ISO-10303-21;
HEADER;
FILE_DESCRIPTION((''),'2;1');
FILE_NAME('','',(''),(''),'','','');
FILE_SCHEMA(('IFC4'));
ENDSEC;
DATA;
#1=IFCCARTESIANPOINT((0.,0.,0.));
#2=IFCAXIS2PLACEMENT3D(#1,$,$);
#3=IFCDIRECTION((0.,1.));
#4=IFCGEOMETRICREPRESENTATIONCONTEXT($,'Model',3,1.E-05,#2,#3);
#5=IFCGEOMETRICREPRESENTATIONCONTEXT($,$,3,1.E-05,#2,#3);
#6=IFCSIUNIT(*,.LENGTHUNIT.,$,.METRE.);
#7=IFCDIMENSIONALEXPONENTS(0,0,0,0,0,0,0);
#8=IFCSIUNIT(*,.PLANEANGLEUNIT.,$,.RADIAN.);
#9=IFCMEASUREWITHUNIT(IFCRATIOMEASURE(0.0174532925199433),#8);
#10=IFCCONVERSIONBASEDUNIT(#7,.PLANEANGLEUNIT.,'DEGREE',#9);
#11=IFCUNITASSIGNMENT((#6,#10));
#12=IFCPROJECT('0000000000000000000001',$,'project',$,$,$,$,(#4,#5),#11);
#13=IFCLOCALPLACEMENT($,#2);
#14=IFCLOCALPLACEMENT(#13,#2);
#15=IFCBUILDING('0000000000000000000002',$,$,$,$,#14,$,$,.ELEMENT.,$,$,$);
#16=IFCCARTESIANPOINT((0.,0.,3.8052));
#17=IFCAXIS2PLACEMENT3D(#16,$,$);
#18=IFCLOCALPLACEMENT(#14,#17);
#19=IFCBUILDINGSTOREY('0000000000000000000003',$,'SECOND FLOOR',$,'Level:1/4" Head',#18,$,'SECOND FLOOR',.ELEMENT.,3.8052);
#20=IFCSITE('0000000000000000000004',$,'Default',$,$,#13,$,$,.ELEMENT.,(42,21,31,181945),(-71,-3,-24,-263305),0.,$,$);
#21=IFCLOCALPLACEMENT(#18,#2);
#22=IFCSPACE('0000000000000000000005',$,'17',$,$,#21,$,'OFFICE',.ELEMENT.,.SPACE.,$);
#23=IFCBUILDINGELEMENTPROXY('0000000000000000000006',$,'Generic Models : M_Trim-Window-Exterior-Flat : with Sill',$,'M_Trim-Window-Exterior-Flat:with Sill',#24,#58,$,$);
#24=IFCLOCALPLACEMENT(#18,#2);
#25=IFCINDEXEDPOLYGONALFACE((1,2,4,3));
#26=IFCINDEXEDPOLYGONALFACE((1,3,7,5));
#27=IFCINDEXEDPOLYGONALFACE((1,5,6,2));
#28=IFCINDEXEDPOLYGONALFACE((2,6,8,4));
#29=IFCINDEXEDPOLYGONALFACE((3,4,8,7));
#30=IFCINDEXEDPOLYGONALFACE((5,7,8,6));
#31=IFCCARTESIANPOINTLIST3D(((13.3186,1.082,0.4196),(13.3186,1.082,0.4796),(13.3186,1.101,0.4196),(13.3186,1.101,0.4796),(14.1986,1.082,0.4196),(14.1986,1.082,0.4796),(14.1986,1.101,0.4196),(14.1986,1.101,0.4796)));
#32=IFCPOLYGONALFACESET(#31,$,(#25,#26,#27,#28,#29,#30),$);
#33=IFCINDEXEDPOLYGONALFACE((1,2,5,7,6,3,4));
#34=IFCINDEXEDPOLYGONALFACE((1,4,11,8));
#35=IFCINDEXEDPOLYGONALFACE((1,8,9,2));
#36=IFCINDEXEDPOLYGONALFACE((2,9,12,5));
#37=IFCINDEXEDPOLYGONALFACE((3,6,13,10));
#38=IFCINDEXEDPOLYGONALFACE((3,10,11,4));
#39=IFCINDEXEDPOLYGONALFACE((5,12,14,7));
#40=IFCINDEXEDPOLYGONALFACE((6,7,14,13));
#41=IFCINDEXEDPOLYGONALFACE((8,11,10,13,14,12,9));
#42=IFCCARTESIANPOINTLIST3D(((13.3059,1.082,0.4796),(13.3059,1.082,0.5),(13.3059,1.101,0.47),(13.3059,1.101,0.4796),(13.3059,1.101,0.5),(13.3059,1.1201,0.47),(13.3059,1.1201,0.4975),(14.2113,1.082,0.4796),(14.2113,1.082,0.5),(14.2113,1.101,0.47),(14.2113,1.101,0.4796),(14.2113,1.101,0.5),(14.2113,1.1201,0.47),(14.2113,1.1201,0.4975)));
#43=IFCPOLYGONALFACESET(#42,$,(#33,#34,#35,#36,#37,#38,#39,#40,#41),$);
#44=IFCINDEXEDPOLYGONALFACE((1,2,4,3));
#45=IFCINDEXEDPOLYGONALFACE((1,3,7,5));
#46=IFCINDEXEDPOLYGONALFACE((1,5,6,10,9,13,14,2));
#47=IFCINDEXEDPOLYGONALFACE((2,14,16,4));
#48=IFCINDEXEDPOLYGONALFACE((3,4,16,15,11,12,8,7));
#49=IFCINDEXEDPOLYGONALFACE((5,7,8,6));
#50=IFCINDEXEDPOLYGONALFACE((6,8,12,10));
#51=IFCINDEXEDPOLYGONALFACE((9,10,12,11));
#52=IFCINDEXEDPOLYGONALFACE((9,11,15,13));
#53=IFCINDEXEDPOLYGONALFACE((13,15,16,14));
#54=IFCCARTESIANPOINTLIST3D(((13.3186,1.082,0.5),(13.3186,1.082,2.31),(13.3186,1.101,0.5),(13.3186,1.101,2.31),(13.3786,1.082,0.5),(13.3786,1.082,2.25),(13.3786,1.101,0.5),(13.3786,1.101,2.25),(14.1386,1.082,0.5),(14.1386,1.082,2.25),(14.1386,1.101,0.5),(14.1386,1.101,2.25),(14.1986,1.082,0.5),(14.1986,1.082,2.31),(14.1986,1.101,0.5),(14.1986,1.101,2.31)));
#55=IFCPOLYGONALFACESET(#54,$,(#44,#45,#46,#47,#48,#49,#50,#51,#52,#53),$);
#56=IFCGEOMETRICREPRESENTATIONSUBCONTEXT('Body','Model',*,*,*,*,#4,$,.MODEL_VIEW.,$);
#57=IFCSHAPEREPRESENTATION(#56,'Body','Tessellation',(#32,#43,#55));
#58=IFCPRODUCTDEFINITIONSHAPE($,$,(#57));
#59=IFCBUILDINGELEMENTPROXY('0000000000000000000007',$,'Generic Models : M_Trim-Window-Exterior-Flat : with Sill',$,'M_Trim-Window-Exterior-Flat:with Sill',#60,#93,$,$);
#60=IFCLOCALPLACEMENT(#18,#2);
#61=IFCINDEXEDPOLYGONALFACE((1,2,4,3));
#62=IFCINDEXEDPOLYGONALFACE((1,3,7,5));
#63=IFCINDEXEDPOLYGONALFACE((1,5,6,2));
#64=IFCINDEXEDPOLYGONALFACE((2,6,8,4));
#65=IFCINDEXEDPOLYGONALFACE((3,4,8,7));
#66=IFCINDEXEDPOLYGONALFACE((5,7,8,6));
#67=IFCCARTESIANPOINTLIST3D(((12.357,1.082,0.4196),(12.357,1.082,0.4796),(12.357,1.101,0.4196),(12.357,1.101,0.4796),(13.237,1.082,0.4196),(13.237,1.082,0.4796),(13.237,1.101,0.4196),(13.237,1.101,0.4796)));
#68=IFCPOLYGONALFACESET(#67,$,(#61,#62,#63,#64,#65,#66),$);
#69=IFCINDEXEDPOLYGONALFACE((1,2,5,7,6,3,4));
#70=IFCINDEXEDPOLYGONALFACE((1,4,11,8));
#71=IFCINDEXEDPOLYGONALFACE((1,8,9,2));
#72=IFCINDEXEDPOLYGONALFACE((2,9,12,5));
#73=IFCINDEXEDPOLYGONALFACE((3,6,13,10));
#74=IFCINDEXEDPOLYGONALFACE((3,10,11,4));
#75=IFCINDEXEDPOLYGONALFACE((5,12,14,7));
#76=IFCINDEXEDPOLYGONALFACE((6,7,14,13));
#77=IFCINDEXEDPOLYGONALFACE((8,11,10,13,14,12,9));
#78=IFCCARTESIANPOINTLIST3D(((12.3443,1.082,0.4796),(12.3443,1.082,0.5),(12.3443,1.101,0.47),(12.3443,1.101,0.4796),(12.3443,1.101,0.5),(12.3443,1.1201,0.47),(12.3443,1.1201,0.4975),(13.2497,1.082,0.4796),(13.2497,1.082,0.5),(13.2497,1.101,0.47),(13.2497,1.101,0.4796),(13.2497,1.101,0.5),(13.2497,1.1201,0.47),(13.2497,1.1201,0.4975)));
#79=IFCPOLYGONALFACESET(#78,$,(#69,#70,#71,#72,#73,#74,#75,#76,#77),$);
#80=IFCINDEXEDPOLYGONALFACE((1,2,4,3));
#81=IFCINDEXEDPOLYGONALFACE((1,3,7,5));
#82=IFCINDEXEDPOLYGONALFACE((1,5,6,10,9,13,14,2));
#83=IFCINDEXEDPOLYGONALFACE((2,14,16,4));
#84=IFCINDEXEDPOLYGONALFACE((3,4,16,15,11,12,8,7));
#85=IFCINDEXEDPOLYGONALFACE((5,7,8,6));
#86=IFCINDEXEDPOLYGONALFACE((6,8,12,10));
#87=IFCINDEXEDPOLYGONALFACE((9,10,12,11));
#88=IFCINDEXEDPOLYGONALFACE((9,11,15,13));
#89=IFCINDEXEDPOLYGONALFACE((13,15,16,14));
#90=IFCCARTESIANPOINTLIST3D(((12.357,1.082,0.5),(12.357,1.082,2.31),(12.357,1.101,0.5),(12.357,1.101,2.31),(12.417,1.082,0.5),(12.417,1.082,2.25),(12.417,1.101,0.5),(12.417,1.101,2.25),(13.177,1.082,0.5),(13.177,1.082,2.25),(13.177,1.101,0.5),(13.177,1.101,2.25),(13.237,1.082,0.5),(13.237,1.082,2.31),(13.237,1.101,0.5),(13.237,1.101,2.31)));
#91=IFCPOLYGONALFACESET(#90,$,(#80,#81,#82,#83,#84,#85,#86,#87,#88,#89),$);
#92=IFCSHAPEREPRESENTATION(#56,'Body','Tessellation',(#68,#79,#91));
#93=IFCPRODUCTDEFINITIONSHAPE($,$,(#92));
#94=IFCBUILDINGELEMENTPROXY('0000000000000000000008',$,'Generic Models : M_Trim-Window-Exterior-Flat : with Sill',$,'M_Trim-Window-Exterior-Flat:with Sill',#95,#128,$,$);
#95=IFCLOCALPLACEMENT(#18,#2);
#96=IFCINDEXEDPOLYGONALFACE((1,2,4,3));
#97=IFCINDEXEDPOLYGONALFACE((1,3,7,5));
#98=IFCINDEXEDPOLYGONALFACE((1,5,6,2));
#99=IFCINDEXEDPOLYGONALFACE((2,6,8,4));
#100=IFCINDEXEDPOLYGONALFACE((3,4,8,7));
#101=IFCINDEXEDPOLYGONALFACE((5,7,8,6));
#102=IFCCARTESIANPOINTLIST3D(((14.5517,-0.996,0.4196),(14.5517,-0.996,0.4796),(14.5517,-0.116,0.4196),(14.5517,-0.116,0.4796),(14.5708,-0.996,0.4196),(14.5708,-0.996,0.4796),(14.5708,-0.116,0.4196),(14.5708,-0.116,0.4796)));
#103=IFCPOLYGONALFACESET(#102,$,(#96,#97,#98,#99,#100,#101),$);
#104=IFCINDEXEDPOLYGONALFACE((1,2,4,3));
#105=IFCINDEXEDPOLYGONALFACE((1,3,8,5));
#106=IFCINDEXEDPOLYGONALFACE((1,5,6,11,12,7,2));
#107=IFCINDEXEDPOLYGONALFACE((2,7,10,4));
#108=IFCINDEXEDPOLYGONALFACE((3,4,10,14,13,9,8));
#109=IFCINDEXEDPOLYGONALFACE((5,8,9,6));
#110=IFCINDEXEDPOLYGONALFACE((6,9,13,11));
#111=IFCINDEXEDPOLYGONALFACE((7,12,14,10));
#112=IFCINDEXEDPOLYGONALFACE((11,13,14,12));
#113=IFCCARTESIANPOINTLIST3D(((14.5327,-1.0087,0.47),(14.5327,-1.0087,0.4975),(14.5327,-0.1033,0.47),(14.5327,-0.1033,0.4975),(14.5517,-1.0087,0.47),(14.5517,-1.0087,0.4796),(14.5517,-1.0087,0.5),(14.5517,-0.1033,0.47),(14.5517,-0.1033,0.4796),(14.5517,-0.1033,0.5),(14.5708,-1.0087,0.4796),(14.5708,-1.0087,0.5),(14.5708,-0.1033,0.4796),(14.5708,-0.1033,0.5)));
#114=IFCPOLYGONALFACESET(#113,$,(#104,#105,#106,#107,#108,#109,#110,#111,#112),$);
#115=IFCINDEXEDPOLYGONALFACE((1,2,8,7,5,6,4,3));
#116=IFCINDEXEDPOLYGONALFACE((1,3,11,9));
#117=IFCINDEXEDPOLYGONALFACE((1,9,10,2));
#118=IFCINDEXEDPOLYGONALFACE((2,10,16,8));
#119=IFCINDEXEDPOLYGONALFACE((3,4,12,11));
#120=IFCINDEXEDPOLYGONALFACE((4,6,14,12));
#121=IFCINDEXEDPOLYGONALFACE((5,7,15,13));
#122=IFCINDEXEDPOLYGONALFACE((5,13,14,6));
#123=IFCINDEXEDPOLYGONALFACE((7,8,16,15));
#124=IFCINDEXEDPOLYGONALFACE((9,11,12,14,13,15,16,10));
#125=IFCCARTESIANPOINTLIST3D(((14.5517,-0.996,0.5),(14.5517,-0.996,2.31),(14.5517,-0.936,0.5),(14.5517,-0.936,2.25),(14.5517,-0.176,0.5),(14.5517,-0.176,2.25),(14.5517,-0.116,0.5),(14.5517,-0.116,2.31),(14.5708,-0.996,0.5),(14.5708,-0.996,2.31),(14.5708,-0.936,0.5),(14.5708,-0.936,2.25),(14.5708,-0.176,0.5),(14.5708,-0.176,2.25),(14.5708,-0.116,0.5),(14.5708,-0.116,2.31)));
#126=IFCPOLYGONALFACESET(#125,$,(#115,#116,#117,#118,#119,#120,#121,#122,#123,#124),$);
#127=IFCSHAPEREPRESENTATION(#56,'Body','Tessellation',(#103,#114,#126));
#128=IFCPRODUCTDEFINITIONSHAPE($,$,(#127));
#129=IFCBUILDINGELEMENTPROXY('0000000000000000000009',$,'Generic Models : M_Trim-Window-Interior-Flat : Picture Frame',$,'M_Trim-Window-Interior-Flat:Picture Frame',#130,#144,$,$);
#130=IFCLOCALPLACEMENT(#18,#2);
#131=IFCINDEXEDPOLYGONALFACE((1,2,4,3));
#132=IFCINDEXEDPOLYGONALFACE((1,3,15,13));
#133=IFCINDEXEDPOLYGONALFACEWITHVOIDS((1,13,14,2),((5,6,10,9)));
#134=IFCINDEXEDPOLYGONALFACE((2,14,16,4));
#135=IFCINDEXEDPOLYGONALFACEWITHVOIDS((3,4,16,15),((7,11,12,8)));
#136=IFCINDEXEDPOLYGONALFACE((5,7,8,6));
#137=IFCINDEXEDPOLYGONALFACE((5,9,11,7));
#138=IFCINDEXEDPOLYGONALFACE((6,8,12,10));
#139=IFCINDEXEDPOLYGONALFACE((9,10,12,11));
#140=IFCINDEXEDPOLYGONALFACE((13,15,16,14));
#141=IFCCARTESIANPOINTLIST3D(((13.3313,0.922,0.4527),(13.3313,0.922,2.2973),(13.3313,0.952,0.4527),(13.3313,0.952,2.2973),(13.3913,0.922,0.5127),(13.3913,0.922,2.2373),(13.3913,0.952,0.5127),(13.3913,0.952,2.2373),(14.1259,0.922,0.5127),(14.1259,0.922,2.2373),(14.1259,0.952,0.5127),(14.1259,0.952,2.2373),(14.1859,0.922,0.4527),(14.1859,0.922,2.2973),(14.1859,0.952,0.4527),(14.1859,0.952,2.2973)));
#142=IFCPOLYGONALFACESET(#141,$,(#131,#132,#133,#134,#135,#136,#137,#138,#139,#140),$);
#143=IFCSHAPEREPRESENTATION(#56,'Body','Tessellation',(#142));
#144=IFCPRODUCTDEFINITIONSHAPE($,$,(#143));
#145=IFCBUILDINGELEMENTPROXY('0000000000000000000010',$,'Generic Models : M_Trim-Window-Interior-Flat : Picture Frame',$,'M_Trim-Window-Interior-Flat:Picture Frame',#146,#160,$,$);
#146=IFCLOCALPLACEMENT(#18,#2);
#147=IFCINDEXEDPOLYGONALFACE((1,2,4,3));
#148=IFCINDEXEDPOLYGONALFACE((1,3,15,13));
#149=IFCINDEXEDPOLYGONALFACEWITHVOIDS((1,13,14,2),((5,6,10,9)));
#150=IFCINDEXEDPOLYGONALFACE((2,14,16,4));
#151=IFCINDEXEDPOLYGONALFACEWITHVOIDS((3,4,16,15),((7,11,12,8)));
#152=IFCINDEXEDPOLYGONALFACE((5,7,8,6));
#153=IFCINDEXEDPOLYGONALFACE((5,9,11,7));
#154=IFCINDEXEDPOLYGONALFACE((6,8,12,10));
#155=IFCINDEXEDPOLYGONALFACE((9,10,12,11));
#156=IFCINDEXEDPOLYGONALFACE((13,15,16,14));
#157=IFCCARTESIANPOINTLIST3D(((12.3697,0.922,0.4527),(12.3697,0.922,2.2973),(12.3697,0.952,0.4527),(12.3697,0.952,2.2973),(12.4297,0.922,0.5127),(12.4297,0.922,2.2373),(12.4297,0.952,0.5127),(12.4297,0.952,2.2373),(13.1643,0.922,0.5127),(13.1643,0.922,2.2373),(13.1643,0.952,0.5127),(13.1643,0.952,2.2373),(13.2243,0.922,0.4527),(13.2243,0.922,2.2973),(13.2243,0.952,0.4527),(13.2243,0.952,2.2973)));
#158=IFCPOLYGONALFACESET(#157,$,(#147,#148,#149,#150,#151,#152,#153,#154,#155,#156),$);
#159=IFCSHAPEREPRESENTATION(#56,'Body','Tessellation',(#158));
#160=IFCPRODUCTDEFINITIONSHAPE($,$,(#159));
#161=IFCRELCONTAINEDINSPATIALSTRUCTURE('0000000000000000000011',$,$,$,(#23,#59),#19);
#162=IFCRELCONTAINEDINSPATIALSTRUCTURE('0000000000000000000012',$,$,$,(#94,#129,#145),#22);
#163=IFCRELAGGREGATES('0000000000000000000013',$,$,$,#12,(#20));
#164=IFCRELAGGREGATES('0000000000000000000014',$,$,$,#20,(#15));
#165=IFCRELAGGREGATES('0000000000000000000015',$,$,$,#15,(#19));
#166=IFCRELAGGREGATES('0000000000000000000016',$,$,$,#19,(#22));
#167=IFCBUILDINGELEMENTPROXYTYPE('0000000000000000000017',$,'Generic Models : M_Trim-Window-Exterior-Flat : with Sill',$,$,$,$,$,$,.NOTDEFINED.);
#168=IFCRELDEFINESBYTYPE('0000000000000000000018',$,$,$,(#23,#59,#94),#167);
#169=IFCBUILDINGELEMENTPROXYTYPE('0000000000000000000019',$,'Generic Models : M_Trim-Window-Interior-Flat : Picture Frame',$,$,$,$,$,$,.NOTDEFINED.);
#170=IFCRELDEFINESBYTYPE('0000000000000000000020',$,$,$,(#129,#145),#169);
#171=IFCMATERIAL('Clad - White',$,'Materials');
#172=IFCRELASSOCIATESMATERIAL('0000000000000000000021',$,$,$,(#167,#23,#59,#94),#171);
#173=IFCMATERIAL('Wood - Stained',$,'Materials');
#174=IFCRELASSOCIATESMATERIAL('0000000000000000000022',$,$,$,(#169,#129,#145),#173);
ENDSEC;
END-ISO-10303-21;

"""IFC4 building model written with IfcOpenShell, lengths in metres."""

from ifc_helpers import new_model, entity, si_unit, converted_unit, direction, frame, origin, origin_2d_with_axis, place, context, subcontext, project, spatial, polyline, rectangle, outline, extrude, source, transform, mapped, material, type_object, type_shapes, element, save


model = new_model("IFC4")

# Units and contexts
model_context = context("Model", 3, precision=1e-05, world=origin(), true_north=direction((0.0, 1.0)))
context_of_model = context(None, 3, precision=1e-05, world=origin(), true_north=direction((0.0, 1.0)))
body_context = subcontext(model_context, "Body", "Model", "MODEL_VIEW")
ifc_project = project(units=[si_unit("LENGTHUNIT", "METRE"), converted_unit("PLANEANGLEUNIT", "DEGREE", entity("IfcRatioMeasure", 0.0174532925199433), si_unit("PLANEANGLEUNIT", "RADIAN"), dimensions=[0, 0, 0, 0, 0, 0, 0])], contexts=[model_context, context_of_model])

# Site, building, storey
site_placement = place(None, origin())
site = spatial("IfcSite", under=ifc_project, at=site_placement, Name="Default", CompositionType="ELEMENT", RefLatitude=(42, 21, 31, 181945), RefLongitude=(-71, -3, -24, -263305), RefElevation=0.0)
building_placement = place(site_placement, origin())
building = spatial("IfcBuilding", under=site, at=building_placement, CompositionType="ELEMENT")
storey_placement = place(building_placement, frame((0.0, 0.0, 3.8052)))
storey = spatial("IfcBuildingStorey", under=building, at=storey_placement, Name="SECOND FLOOR", ObjectType="Level:1/4\" Head", LongName="SECOND FLOOR", CompositionType="ELEMENT", Elevation=3.8052)

# Building element proxies
ifc_material_1 = material(Name="Clad - White", Category="Materials")
ifc_material_2 = material(Name="Wood - Stained", Category="Materials")
building_element_proxy_type_1 = type_object("IfcBuildingElementProxyType", Name="Generic Models : M_Trim-Window-Exterior-Flat : with Sill", PredefinedType="NOTDEFINED", material=ifc_material_1)
shared_shape_1 = source(origin(), body_context, "Body", "SweptSolid", [
    extrude(rectangle(XDim=0.88, YDim=0.06, at=origin_2d_with_axis()), frame((0.0, -1.8004, 0.0), z_axis=(0.0, 0.0, 1.0), x_axis=(-1.0, 0.0, 0.0)), (0.0, 0.0, 1.0), 0.0191),
    extrude(outline(polyline([(-0.019, -0.0152), (0.0, -0.0152), (0.0, -0.0057), (0.019, -0.0057), (0.019, 0.0148), (0.0, 0.0148), (-0.019, 0.0123), (-0.019, -0.0152)])), frame((-0.4527, -1.7648, 0.019), z_axis=(1.0, 0.0, 0.0), x_axis=(0.0, 0.0, -1.0)), (0.0, 0.0, 1.0), 0.9054),
    extrude(outline(polyline([(-0.92, -0.44), (0.89, -0.44), (0.89, -0.38), (-0.86, -0.38), (-0.86, 0.38), (0.89, 0.38), (0.89, 0.44), (-0.92, 0.44), (-0.92, -0.44)])), frame((0.0, -0.86, 0.0), z_axis=(0.0, 0.0, 1.0), x_axis=(0.0, -1.0, 0.0)), (0.0, 0.0, 1.0), 0.0191),
])
type_shapes(building_element_proxy_type_1, [shared_shape_1])
for number, where, z_axis, x_axis, name in (
    (1, (13.7586, 1.082, 2.25), (0.0, 1.0, 0.0), (-1.0, 0.0, 0.0), "Generic Models : M_Trim-Window-Exterior-Flat : with Sill"),
    (2, (12.797, 1.082, 2.25), (0.0, 1.0, 0.0), (-1.0, 0.0, 0.0), "Generic Models : M_Trim-Window-Exterior-Flat : with Sill"),
):
    element("IfcBuildingElementProxy", number, at=place(storey_placement, frame(where, z_axis=z_axis, x_axis=x_axis)), inside=storey, type_object=building_element_proxy_type_1, material=ifc_material_1, Name=name, ObjectType="M_Trim-Window-Exterior-Flat:with Sill", context=body_context, shape_type="MappedRepresentation", body=[
        mapped(shared_shape_1, transform((0.0, 0.0, 0.0), scale=1.0)),
    ])

# Shared definitions
space_placement = place(storey_placement, origin())
space = spatial("IfcSpace", under=storey, at=space_placement, Name="17", LongName="OFFICE", CompositionType="ELEMENT", PredefinedType="SPACE")

# Building element proxies
proxy_1_placement = place(space_placement, frame((14.5708, -0.556, 2.25), z_axis=(-1.0, 0.0, 0.0), x_axis=(0.0, -1.0, 0.0)))
element("IfcBuildingElementProxy", 3, at=proxy_1_placement, inside=space, type_object=building_element_proxy_type_1, material=ifc_material_1, Name="Generic Models : M_Trim-Window-Exterior-Flat : with Sill", ObjectType="M_Trim-Window-Exterior-Flat:with Sill", context=body_context, shape_type="MappedRepresentation", body=[
    mapped(shared_shape_1, transform((0.0, 0.0, 0.0), scale=1.0)),
])
building_element_proxy_type_2 = type_object("IfcBuildingElementProxyType", Name="Generic Models : M_Trim-Window-Interior-Flat : Picture Frame", PredefinedType="NOTDEFINED", material=ifc_material_2)
shared_shape_2 = source(origin(), body_context, "Body", "SweptSolid", [
    extrude(outline(polyline([(-0.4273, -0.9223), (0.4273, -0.9223), (0.4273, 0.9223), (-0.4273, 0.9223), (-0.4273, -0.9223)]), holes=[polyline([(-0.3673, -0.8623), (-0.3673, 0.8623), (0.3673, 0.8623), (0.3673, -0.8623), (-0.3673, -0.8623)])]), frame((0.0, -0.875, 0.0), z_axis=(0.0, 0.0, 1.0), x_axis=(-1.0, 0.0, 0.0)), (0.0, 0.0, 1.0), 0.03),
])
type_shapes(building_element_proxy_type_2, [shared_shape_2])
for number, where, z_axis, x_axis, name in (
    (4, (13.7586, 0.952, 2.25), (0.0, -1.0, 0.0), (1.0, 0.0, 0.0), "Generic Models : M_Trim-Window-Interior-Flat : Picture Frame"),
    (5, (12.797, 0.952, 2.25), (0.0, -1.0, 0.0), (1.0, 0.0, 0.0), "Generic Models : M_Trim-Window-Interior-Flat : Picture Frame"),
):
    element("IfcBuildingElementProxy", number, at=place(space_placement, frame(where, z_axis=z_axis, x_axis=x_axis)), inside=space, type_object=building_element_proxy_type_2, material=ifc_material_2, Name=name, ObjectType="M_Trim-Window-Interior-Flat:Picture Frame", context=body_context, shape_type="MappedRepresentation", body=[
        mapped(shared_shape_2, transform((0.0, 0.0, 0.0), scale=1.0)),
    ])

save(model, "model.ifc")
